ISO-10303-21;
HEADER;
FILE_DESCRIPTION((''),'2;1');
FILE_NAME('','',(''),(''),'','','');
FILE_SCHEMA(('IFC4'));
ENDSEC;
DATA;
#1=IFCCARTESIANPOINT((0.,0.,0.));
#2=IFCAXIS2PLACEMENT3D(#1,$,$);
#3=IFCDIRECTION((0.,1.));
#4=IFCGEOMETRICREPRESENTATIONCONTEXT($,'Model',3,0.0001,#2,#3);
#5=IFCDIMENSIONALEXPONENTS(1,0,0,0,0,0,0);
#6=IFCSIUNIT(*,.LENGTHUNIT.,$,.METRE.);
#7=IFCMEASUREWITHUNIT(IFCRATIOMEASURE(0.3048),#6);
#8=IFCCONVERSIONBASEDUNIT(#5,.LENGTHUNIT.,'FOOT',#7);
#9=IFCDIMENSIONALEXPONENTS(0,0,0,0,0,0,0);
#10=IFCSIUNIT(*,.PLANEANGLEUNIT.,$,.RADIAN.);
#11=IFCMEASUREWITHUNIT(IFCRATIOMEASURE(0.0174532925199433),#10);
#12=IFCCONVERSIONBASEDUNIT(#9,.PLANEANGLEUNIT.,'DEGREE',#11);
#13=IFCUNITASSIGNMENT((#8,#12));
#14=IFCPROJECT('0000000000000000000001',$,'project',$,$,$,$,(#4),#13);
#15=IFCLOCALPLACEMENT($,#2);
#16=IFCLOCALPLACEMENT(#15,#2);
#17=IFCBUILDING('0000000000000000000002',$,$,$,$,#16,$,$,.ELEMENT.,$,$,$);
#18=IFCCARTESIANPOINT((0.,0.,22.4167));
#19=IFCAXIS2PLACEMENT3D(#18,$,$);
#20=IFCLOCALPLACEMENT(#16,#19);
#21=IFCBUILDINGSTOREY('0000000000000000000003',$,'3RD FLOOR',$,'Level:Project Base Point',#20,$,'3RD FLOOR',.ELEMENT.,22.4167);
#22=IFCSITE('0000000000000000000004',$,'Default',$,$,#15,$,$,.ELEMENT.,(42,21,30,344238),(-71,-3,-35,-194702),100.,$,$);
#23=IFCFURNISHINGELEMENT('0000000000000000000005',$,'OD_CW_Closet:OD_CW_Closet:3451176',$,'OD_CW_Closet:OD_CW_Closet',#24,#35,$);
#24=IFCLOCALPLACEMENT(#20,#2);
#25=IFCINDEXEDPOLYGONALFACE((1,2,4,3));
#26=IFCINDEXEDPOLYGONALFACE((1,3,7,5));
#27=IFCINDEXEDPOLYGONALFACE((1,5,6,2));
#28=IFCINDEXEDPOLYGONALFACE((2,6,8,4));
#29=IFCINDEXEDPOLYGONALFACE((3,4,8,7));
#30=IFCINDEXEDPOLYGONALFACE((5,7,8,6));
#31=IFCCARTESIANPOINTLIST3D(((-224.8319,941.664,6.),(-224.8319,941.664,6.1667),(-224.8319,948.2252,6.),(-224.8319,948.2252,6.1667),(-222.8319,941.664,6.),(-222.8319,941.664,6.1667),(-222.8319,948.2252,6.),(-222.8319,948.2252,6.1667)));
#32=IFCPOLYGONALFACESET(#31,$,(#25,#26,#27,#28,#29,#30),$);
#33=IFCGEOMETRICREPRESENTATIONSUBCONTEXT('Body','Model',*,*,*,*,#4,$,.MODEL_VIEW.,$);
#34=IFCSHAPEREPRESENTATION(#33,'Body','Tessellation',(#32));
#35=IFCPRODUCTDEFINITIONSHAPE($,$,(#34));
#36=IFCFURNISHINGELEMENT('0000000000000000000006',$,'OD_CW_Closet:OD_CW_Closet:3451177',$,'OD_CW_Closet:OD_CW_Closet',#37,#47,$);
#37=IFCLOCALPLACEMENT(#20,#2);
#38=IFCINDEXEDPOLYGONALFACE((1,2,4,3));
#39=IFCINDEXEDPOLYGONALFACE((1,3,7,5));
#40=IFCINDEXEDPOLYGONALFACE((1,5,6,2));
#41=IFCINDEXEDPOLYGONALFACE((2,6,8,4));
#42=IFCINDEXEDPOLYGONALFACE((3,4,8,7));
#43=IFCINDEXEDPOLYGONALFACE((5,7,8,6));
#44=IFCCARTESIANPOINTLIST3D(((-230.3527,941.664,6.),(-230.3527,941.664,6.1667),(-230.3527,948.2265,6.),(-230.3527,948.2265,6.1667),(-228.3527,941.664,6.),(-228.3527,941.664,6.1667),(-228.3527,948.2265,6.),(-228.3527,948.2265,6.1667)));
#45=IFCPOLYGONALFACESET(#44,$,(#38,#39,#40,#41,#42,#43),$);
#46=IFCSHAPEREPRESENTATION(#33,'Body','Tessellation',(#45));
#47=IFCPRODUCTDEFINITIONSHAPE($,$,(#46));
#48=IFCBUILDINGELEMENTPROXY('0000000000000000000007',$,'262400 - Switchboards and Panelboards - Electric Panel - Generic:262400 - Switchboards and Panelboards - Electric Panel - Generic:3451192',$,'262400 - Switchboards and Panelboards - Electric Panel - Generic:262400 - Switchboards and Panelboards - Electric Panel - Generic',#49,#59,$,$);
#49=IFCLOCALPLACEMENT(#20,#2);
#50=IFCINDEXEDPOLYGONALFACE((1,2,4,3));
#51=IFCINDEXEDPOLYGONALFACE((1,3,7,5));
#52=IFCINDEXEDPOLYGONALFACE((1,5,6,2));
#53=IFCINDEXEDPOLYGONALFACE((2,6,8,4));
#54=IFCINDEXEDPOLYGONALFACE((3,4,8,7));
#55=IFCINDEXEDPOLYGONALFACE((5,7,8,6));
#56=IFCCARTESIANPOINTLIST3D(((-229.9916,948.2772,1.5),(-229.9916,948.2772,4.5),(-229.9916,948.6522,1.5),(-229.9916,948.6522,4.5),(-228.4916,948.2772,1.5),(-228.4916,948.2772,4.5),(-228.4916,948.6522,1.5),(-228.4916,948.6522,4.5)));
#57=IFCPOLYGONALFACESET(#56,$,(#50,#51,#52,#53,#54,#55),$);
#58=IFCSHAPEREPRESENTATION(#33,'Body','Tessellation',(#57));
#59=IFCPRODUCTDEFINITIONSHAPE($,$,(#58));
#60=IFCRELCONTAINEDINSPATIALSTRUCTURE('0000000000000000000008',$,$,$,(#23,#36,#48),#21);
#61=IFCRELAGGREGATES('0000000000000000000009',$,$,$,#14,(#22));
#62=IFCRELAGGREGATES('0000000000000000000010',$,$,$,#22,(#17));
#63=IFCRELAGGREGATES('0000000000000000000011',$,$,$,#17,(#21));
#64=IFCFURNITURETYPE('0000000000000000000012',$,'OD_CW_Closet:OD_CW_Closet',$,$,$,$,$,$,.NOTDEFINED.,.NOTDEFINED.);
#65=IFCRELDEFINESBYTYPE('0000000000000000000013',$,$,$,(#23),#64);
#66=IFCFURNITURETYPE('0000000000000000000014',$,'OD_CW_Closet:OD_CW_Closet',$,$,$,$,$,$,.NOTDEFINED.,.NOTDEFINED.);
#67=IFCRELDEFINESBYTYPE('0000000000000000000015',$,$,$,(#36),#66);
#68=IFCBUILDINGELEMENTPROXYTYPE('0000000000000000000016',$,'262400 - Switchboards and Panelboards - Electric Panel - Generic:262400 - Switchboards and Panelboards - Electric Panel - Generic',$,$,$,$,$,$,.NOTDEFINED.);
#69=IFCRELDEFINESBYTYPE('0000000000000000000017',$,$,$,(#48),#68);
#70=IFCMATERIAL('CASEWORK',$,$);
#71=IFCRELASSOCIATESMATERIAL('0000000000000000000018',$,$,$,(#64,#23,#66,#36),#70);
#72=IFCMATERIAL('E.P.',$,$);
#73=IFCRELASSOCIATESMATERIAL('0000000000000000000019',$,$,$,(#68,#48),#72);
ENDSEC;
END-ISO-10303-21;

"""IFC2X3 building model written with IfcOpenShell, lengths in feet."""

from ifc_helpers import new_model, entity, si_unit, converted_unit, direction, frame, origin, origin_2d_with_axis, place, context, subcontext, project, spatial, rectangle, extrude, source, transform, mapped, material, type_object, type_shapes, element, save


model = new_model("IFC2X3")

# Units and contexts
model_context = context("Model", 3, precision=0.0001, world=origin(), true_north=direction((0.0, 1.0)))
body_context = subcontext(model_context, "Body", "Model", "MODEL_VIEW")
ifc_project = project(units=[converted_unit("LENGTHUNIT", "FOOT", entity("IfcRatioMeasure", 0.3048), si_unit("LENGTHUNIT", "METRE"), dimensions=[1, 0, 0, 0, 0, 0, 0]), converted_unit("PLANEANGLEUNIT", "DEGREE", entity("IfcRatioMeasure", 0.0174532925199433), si_unit("PLANEANGLEUNIT", "RADIAN"), dimensions=[0, 0, 0, 0, 0, 0, 0])], contexts=[model_context])

# Site, building, storey
site_placement = place(None, origin())
site = spatial("IfcSite", under=ifc_project, at=site_placement, Name="Default", CompositionType="ELEMENT", RefLatitude=(42, 21, 30, 344238), RefLongitude=(-71, -3, -35, -194702), RefElevation=100.0)
building_placement = place(site_placement, origin())
building = spatial("IfcBuilding", under=site, at=building_placement, CompositionType="ELEMENT")
storey_placement = place(building_placement, frame((0.0, 0.0, 22.4167)))
storey = spatial("IfcBuildingStorey", under=building, at=storey_placement, Name="3RD FLOOR", ObjectType="Level:Project Base Point", LongName="3RD FLOOR", CompositionType="ELEMENT", Elevation=22.4167)

# Furnishing elements
ifc_material_1 = material(Name="CASEWORK")
furniture_type_1 = type_object("IfcFurnitureType", Name="OD_CW_Closet:OD_CW_Closet", material=ifc_material_1)
shared_shape_1 = source(origin(), body_context, "Body", "SweptSolid", [
    extrude(rectangle(XDim=2.0, YDim=6.5611, at=origin_2d_with_axis()), frame((3.2806, 1.0, 0.0), z_axis=(0.0, 0.0, 1.0), x_axis=(0.0, -1.0, 0.0)), (0.0, 0.0, 1.0), 0.1667),
])
type_shapes(furniture_type_1, [shared_shape_1])
furnishing_1_placement = place(storey_placement, frame((-224.8319, 948.2252, 6.0), z_axis=(0.0, 0.0, 1.0), x_axis=(0.0, -1.0, 0.0)))
element("IfcFurnishingElement", 1, at=furnishing_1_placement, inside=storey, type_object=furniture_type_1, material=ifc_material_1, Name="OD_CW_Closet:OD_CW_Closet:3451176", ObjectType="OD_CW_Closet:OD_CW_Closet", context=body_context, shape_type="MappedRepresentation", body=[
    mapped(shared_shape_1, transform((0.0, 0.0, 0.0), scale=1.0)),
])
furniture_type_2 = type_object("IfcFurnitureType", Name="OD_CW_Closet:OD_CW_Closet", material=ifc_material_1)
shared_shape_2 = source(origin(), body_context, "Body", "SweptSolid", [
    extrude(rectangle(XDim=6.5625, YDim=2.0, at=origin_2d_with_axis()), frame((3.2813, 1.0, 0.0)), (0.0, 0.0, 1.0), 0.1667),
])
type_shapes(furniture_type_2, [shared_shape_2])
furnishing_2_placement = place(storey_placement, frame((-230.3527, 948.2265, 6.0), z_axis=(0.0, 0.0, 1.0), x_axis=(0.0, -1.0, 0.0)))
element("IfcFurnishingElement", 2, at=furnishing_2_placement, inside=storey, type_object=furniture_type_2, material=ifc_material_1, Name="OD_CW_Closet:OD_CW_Closet:3451177", ObjectType="OD_CW_Closet:OD_CW_Closet", context=body_context, shape_type="MappedRepresentation", body=[
    mapped(shared_shape_2, transform((0.0, 0.0, 0.0), scale=1.0)),
])

# Building element proxy
ifc_material_2 = material(Name="E.P.")
building_element_proxy_type_1 = type_object("IfcBuildingElementProxyType", Name="262400 - Switchboards and Panelboards - Electric Panel - Generic:262400 - Switchboards and Panelboards - Electric Panel - Generic", PredefinedType="NOTDEFINED", material=ifc_material_2)
shared_shape_3 = source(origin(), body_context, "Body", "SweptSolid", [
    extrude(rectangle(XDim=1.5, YDim=0.375, at=origin_2d_with_axis()), frame((0.75, 0.1875, 0.0), z_axis=(0.0, 0.0, 1.0), x_axis=(-1.0, 0.0, 0.0)), (0.0, 0.0, 1.0), 3.0),
])
type_shapes(building_element_proxy_type_1, [shared_shape_3])
proxy_1_placement = place(storey_placement, frame((-228.4916, 948.6522, 1.5), z_axis=(0.0, 0.0, 1.0), x_axis=(-1.0, 0.0, 0.0)))
element("IfcBuildingElementProxy", 3, at=proxy_1_placement, inside=storey, type_object=building_element_proxy_type_1, material=ifc_material_2, Name="262400 - Switchboards and Panelboards - Electric Panel - Generic:262400 - Switchboards and Panelboards - Electric Panel - Generic:3451192", ObjectType="262400 - Switchboards and Panelboards - Electric Panel - Generic:262400 - Switchboards and Panelboards - Electric Panel - Generic", context=body_context, shape_type="MappedRepresentation", body=[
    mapped(shared_shape_3, transform((0.0, 0.0, 0.0), scale=1.0)),
])

save(model, "model.ifc")
